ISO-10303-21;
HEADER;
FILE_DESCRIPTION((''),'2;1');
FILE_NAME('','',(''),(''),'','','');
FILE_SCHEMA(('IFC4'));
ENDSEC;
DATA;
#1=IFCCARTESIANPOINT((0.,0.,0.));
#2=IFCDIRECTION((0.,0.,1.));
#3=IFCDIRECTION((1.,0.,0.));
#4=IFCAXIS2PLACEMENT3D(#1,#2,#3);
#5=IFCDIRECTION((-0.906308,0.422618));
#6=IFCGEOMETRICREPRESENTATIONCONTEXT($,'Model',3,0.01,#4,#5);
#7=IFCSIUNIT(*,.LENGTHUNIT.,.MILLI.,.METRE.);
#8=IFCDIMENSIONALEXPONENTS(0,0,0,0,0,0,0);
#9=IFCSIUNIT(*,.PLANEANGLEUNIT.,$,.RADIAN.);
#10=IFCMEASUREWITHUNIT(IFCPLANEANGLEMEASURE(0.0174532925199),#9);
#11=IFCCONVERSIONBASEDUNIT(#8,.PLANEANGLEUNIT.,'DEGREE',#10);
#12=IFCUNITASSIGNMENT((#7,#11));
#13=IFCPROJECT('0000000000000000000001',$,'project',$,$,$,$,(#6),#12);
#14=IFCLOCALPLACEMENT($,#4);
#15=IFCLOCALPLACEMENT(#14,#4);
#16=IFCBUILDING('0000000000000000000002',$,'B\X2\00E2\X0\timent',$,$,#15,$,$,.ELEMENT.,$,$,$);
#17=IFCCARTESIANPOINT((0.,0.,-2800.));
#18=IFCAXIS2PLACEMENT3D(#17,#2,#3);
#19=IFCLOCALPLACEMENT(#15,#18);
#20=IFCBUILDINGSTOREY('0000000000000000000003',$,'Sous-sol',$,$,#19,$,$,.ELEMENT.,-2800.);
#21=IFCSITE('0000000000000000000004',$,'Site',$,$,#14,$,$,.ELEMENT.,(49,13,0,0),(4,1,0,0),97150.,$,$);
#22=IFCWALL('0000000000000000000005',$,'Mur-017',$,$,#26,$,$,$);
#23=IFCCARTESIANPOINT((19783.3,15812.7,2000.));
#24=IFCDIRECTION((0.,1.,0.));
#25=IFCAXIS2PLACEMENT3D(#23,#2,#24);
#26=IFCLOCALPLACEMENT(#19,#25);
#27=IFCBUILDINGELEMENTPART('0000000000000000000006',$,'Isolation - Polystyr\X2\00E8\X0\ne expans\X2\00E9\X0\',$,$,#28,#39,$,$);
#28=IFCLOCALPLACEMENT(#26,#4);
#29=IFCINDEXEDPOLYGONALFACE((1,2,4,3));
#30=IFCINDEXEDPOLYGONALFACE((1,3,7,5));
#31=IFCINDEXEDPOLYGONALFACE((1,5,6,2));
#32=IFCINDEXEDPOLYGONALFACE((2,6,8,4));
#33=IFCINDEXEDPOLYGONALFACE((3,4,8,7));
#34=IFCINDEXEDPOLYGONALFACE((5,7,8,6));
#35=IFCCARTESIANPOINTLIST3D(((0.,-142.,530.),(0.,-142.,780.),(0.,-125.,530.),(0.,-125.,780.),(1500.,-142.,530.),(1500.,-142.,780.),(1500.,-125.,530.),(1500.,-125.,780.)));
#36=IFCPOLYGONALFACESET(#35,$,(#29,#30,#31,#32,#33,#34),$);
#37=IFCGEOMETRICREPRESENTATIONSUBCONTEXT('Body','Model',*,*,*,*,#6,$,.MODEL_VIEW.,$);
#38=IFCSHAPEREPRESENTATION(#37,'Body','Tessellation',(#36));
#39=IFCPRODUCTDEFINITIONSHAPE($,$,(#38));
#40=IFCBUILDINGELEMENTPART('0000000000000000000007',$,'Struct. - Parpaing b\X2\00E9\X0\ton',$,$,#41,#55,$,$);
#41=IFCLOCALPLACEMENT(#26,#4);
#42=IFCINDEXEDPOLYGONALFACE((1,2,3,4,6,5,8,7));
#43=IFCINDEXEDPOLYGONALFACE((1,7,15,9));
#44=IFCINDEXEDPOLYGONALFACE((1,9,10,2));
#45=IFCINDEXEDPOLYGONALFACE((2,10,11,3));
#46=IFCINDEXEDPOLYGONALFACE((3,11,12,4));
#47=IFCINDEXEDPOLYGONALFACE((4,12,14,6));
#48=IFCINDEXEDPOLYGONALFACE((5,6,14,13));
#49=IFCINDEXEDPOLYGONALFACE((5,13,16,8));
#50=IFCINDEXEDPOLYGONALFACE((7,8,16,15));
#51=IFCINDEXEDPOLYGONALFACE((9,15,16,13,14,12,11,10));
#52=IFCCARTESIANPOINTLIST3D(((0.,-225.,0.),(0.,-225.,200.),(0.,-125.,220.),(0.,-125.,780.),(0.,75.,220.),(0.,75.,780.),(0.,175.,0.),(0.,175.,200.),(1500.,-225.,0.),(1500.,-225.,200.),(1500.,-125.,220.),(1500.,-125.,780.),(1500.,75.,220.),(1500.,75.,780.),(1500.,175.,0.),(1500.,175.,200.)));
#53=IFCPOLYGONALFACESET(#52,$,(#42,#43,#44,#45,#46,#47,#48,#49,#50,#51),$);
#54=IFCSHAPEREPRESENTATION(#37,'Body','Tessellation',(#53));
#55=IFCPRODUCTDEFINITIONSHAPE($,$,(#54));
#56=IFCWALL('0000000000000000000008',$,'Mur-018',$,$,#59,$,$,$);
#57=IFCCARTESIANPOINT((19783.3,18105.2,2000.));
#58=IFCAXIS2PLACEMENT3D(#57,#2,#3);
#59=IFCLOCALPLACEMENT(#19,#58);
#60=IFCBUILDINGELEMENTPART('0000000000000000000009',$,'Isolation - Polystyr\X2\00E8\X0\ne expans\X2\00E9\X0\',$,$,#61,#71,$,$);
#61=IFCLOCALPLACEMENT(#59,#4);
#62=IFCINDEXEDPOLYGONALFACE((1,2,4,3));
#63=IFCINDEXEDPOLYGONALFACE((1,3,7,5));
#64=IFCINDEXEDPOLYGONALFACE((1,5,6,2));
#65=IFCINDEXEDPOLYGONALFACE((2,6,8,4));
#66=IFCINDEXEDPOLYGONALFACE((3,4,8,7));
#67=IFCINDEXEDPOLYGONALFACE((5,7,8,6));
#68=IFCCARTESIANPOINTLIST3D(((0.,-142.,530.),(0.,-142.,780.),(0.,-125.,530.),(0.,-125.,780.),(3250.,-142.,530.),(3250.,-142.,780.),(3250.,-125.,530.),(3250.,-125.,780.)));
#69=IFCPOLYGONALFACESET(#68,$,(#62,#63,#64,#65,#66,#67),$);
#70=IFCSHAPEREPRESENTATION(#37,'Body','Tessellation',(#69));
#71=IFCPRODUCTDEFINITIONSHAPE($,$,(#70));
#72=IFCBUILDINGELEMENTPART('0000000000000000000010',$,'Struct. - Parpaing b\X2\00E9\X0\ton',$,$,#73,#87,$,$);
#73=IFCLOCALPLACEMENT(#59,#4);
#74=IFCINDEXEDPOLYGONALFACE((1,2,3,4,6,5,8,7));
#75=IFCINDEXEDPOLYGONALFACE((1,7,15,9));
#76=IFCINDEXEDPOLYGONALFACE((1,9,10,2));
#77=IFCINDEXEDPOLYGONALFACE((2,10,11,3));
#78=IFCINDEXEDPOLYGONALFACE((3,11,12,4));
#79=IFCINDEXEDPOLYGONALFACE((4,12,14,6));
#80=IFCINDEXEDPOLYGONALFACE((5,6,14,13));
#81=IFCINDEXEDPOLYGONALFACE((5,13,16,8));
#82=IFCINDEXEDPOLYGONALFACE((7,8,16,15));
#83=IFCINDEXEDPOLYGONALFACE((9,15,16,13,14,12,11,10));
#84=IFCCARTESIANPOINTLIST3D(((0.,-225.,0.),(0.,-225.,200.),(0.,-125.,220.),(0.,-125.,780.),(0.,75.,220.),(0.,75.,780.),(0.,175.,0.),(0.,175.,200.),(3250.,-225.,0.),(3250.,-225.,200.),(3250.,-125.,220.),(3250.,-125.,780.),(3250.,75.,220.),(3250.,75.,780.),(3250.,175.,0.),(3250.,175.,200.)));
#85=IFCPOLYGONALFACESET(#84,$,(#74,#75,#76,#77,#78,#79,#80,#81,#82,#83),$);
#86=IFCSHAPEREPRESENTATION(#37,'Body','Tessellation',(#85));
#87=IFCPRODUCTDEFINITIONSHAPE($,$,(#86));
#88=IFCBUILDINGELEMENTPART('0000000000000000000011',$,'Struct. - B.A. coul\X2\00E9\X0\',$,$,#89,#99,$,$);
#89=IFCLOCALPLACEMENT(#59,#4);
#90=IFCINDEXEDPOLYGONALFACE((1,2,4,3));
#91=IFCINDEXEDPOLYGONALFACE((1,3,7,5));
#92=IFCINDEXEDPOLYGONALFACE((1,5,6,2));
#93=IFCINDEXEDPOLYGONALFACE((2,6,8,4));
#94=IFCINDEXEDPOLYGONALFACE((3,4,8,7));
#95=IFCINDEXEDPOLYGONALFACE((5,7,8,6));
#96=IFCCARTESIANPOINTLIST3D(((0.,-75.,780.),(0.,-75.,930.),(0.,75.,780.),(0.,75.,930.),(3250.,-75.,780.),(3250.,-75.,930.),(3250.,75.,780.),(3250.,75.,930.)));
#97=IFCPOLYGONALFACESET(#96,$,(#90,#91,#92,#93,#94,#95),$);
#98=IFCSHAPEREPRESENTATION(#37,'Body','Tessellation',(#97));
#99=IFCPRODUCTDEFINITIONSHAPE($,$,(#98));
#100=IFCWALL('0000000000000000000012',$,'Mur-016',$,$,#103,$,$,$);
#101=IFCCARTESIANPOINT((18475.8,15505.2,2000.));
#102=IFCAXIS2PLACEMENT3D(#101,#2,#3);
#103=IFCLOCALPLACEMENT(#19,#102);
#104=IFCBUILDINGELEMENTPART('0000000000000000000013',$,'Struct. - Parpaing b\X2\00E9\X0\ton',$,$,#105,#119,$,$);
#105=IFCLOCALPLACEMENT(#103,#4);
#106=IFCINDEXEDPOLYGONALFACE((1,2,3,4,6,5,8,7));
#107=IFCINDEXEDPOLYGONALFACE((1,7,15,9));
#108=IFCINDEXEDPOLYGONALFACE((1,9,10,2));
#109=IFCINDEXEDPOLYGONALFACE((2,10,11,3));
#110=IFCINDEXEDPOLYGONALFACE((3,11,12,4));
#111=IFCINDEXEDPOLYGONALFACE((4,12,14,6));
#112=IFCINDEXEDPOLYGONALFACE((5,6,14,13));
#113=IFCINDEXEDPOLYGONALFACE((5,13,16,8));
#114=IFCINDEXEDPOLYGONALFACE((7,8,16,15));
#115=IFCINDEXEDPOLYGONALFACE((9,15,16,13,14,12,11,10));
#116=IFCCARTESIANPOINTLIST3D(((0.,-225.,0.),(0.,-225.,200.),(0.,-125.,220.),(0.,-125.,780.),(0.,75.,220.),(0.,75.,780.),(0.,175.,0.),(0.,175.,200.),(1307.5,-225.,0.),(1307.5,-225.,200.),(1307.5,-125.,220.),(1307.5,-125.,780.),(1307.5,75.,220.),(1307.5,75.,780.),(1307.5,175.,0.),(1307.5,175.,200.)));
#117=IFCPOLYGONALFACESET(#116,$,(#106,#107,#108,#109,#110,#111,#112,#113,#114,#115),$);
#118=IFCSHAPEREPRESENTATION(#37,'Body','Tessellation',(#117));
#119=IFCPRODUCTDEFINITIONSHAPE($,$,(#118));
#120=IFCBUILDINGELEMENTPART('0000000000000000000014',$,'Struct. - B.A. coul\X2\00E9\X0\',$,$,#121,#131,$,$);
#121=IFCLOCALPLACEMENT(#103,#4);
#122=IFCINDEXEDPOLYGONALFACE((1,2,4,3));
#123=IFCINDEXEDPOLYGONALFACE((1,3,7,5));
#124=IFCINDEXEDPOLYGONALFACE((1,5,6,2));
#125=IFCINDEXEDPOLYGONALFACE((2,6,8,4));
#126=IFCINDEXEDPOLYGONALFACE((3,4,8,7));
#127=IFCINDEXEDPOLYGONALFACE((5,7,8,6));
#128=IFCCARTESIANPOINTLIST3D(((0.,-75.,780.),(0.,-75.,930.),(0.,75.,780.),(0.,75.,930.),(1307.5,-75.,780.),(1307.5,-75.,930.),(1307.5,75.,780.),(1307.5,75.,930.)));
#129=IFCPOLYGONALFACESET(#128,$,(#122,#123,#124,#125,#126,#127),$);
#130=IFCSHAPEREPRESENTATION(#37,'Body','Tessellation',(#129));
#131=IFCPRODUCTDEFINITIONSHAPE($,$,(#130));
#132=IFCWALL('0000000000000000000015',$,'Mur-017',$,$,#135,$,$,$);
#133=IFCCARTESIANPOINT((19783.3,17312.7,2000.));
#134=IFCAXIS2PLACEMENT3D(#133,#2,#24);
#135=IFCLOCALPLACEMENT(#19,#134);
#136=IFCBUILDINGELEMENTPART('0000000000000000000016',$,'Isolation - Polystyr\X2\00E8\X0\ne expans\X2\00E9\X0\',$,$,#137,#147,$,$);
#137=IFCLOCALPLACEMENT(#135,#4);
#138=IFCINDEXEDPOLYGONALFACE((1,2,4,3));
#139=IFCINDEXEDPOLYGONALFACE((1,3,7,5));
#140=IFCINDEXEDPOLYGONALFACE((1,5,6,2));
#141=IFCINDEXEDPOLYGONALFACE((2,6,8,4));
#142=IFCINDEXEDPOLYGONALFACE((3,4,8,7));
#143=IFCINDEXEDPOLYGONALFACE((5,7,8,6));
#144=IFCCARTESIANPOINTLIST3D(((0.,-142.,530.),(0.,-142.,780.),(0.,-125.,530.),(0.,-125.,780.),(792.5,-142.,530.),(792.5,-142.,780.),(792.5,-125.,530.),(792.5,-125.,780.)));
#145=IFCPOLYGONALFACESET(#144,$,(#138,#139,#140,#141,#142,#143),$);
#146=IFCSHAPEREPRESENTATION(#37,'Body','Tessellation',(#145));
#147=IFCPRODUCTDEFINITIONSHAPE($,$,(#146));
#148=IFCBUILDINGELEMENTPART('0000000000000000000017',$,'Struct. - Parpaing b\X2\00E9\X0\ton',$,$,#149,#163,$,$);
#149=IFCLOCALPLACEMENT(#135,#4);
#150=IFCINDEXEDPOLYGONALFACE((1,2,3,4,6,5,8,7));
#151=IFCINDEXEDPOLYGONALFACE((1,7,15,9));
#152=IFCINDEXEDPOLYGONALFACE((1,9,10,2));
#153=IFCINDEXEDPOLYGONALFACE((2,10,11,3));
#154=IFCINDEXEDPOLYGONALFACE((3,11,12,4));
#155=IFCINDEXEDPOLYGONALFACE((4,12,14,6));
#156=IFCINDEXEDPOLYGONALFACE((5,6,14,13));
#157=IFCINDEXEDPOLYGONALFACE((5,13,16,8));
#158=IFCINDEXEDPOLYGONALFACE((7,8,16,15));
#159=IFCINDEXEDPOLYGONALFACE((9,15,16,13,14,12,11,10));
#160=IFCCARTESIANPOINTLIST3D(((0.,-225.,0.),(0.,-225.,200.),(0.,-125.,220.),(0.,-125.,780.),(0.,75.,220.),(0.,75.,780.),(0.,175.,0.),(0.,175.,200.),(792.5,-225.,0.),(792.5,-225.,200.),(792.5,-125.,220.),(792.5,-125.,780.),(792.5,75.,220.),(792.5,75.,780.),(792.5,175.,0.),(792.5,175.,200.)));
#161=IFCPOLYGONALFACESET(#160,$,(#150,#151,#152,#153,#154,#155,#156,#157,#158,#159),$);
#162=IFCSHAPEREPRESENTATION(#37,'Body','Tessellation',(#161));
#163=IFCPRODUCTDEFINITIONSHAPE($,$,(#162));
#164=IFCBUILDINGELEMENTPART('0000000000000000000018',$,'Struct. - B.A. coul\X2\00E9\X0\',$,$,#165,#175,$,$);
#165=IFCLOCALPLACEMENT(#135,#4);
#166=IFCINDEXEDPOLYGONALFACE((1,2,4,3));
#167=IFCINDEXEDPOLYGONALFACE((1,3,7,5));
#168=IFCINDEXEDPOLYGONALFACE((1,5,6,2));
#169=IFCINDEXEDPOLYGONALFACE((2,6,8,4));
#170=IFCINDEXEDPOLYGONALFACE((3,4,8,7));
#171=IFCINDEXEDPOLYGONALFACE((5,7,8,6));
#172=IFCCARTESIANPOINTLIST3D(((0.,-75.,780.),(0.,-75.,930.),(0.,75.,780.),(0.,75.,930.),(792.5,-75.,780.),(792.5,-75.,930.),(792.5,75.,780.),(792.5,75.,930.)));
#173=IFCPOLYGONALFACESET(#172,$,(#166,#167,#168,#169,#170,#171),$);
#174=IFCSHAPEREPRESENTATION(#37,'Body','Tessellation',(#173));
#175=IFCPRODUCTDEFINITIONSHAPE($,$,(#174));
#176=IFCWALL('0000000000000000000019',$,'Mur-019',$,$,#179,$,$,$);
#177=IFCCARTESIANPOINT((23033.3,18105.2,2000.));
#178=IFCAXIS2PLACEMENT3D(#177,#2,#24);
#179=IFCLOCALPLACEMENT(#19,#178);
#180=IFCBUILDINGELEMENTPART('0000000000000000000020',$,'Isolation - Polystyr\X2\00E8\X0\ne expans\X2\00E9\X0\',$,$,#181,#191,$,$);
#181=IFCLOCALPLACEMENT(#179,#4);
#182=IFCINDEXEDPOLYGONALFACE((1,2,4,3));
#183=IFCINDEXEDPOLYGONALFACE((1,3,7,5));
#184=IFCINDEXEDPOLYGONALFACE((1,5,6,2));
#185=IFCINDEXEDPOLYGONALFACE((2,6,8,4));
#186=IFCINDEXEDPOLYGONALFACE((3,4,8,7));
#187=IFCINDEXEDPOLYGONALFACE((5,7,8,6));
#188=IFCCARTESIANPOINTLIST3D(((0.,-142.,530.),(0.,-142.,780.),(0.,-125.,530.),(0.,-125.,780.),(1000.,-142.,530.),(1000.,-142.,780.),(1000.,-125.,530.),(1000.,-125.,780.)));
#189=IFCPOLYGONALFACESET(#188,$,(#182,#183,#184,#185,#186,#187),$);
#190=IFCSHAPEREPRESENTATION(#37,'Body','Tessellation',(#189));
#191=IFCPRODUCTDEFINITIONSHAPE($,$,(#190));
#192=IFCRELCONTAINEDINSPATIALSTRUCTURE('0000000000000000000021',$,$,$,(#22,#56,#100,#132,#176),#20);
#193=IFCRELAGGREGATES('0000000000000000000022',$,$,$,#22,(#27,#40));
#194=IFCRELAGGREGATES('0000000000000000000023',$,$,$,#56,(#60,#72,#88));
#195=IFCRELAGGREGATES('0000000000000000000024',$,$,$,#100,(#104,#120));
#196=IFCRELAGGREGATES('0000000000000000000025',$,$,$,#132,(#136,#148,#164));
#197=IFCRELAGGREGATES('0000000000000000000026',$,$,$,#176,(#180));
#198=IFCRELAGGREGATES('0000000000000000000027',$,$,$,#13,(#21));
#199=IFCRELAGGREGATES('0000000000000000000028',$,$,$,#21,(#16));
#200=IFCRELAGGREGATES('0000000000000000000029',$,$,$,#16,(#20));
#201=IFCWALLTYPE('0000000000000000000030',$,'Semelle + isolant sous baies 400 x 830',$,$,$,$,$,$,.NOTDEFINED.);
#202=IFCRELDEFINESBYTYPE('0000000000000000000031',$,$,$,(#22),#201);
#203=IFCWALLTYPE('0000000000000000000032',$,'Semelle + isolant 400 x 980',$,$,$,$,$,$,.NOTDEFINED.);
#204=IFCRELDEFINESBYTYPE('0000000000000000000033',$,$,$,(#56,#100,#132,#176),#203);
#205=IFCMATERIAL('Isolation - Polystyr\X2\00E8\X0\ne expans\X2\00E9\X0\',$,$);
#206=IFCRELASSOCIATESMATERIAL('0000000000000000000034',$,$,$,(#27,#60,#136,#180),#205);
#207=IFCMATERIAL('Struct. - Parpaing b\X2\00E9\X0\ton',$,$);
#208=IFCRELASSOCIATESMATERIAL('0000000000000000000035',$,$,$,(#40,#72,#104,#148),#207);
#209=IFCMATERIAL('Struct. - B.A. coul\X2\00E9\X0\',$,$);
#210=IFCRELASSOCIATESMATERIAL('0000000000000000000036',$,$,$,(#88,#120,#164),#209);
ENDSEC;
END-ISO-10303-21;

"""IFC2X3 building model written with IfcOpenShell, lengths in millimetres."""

from ifc_helpers import new_model, entity, si_unit, converted_unit, direction, frame, origin_with_axes, place, context, subcontext, project, spatial, polyline, outline, extrude, material, type_object, element, aggregate, save


model = new_model("IFC2X3")

# Units and contexts
model_context = context("Model", 3, precision=0.01, world=origin_with_axes(), true_north=direction((-0.906308, 0.422618)))
body_context = subcontext(model_context, "Body", "Model", "MODEL_VIEW")
ifc_project = project(units=[si_unit("LENGTHUNIT", "METRE", prefix="MILLI"), converted_unit("PLANEANGLEUNIT", "DEGREE", entity("IfcPlaneAngleMeasure", 0.0174532925199), si_unit("PLANEANGLEUNIT", "RADIAN"), dimensions=[0, 0, 0, 0, 0, 0, 0])], contexts=[model_context])

# Site, building, storey
site_placement = place(None, origin_with_axes())
site = spatial("IfcSite", under=ifc_project, at=site_placement, Name="Site", CompositionType="ELEMENT", RefLatitude=(49, 13, 0, 0), RefLongitude=(4, 1, 0, 0), RefElevation=97150.0)
building_placement = place(site_placement, origin_with_axes())
building = spatial("IfcBuilding", under=site, at=building_placement, Name="Bâtiment", CompositionType="ELEMENT")
storey_placement = place(building_placement, frame((0.0, 0.0, -2800.0), z_axis=(0.0, 0.0, 1.0), x_axis=(1.0, 0.0, 0.0)))
storey = spatial("IfcBuildingStorey", under=building, at=storey_placement, Name="Sous-sol", CompositionType="ELEMENT", Elevation=-2800.0)

# Walls, building element parts
wall_type_1 = type_object("IfcWallType", Name="Semelle + isolant sous baies 400 x 830", PredefinedType="NOTDEFINED")
wall_1_placement = place(storey_placement, frame((19783.3, 15812.7, 2000.0), z_axis=(0.0, 0.0, 1.0), x_axis=(0.0, 1.0, 0.0)))
wall_1 = element("IfcWall", 1, at=wall_1_placement, inside=storey, type_object=wall_type_1, Name="Mur-017")
ifc_material_1 = material(Name="Isolation - Polystyrène expansé")
building_element_part_1_placement = place(wall_1_placement, origin_with_axes())
building_element_part_1 = element("IfcBuildingElementPart", 2, at=building_element_part_1_placement, material=ifc_material_1, Name="Isolation - Polystyrène expansé", context=body_context, shape_type="SweptSolid", body=[
    extrude(outline(polyline([(125.0, 780.0), (125.0, 530.0), (142.0, 530.0), (142.0, 780.0), (125.0, 780.0)])), frame((0.0, 0.0, 0.0), z_axis=(-1.0, 0.0, 0.0), x_axis=(0.0, -1.0, 0.0)), (0.0, 0.0, -1.0), 1500.0),
])
ifc_material_2 = material(Name="Struct. - Parpaing béton")
building_element_part_2_placement = place(wall_1_placement, origin_with_axes())
building_element_part_2 = element("IfcBuildingElementPart", 3, at=building_element_part_2_placement, material=ifc_material_2, Name="Struct. - Parpaing béton", context=body_context, shape_type="SweptSolid", body=[
    extrude(outline(polyline([(-175.0, 200.0), (-175.0, 0.0), (225.0, 0.0), (225.0, 200.0), (125.0, 220.0), (125.0, 780.0), (-75.0, 780.0), (-75.0, 220.0), (-175.0, 200.0)])), frame((0.0, 0.0, 0.0), z_axis=(-1.0, 0.0, 0.0), x_axis=(0.0, -1.0, 0.0)), (0.0, 0.0, -1.0), 1500.0),
])
aggregate(wall_1, [building_element_part_1, building_element_part_2])
wall_type_2 = type_object("IfcWallType", Name="Semelle + isolant 400 x 980", PredefinedType="NOTDEFINED")
wall_2_placement = place(storey_placement, frame((19783.3, 18105.2, 2000.0), z_axis=(0.0, 0.0, 1.0), x_axis=(1.0, 0.0, 0.0)))
wall_2 = element("IfcWall", 4, at=wall_2_placement, inside=storey, type_object=wall_type_2, Name="Mur-018")
building_element_part_3_placement = place(wall_2_placement, origin_with_axes())
building_element_part_3 = element("IfcBuildingElementPart", 5, at=building_element_part_3_placement, material=ifc_material_1, Name="Isolation - Polystyrène expansé", context=body_context, shape_type="SweptSolid", body=[
    extrude(outline(polyline([(125.0, 780.0), (125.0, 530.0), (142.0, 530.0), (142.0, 780.0), (125.0, 780.0)])), frame((0.0, 0.0, 0.0), z_axis=(-1.0, 0.0, 0.0), x_axis=(0.0, -1.0, 0.0)), (0.0, 0.0, -1.0), 3250.0),
])
building_element_part_4_placement = place(wall_2_placement, origin_with_axes())
building_element_part_4 = element("IfcBuildingElementPart", 6, at=building_element_part_4_placement, material=ifc_material_2, Name="Struct. - Parpaing béton", context=body_context, shape_type="SweptSolid", body=[
    extrude(outline(polyline([(-75.0, 220.0), (-175.0, 200.0), (-175.0, 0.0), (225.0, 0.0), (225.0, 200.0), (125.0, 220.0), (125.0, 780.0), (-75.0, 780.0), (-75.0, 220.0)])), frame((0.0, 0.0, 0.0), z_axis=(-1.0, 0.0, 0.0), x_axis=(0.0, -1.0, 0.0)), (0.0, 0.0, -1.0), 3250.0),
])
ifc_material_3 = material(Name="Struct. - B.A. coulé")
building_element_part_5_placement = place(wall_2_placement, origin_with_axes())
building_element_part_5 = element("IfcBuildingElementPart", 7, at=building_element_part_5_placement, material=ifc_material_3, Name="Struct. - B.A. coulé", context=body_context, shape_type="SweptSolid", body=[
    extrude(outline(polyline([(75.0, 780.0), (75.0, 930.0), (-75.0, 930.0), (-75.0, 780.0), (75.0, 780.0)])), frame((0.0, 0.0, 0.0), z_axis=(-1.0, 0.0, 0.0), x_axis=(0.0, -1.0, 0.0)), (0.0, 0.0, -1.0), 3250.0),
])
aggregate(wall_2, [building_element_part_3, building_element_part_4, building_element_part_5])
wall_3_placement = place(storey_placement, frame((18475.8, 15505.2, 2000.0), z_axis=(0.0, 0.0, 1.0), x_axis=(1.0, 0.0, 0.0)))
wall_3 = element("IfcWall", 8, at=wall_3_placement, inside=storey, type_object=wall_type_2, Name="Mur-016")
building_element_part_6_placement = place(wall_3_placement, origin_with_axes())
building_element_part_6 = element("IfcBuildingElementPart", 9, at=building_element_part_6_placement, material=ifc_material_2, Name="Struct. - Parpaing béton", context=body_context, shape_type="SweptSolid", body=[
    extrude(outline(polyline([(-75.0, 220.0), (-175.0, 200.0), (-175.0, 0.0), (225.0, 0.0), (225.0, 200.0), (125.0, 220.0), (125.0, 780.0), (-75.0, 780.0), (-75.0, 220.0)])), frame((0.0, 0.0, 0.0), z_axis=(-1.0, 0.0, 0.0), x_axis=(0.0, -1.0, 0.0)), (0.0, 0.0, -1.0), 1307.5),
])
building_element_part_7_placement = place(wall_3_placement, origin_with_axes())
building_element_part_7 = element("IfcBuildingElementPart", 10, at=building_element_part_7_placement, material=ifc_material_3, Name="Struct. - B.A. coulé", context=body_context, shape_type="SweptSolid", body=[
    extrude(outline(polyline([(75.0, 780.0), (75.0, 930.0), (-75.0, 930.0), (-75.0, 780.0), (75.0, 780.0)])), frame((0.0, 0.0, 0.0), z_axis=(-1.0, 0.0, 0.0), x_axis=(0.0, -1.0, 0.0)), (0.0, 0.0, -1.0), 1307.5),
])
aggregate(wall_3, [building_element_part_6, building_element_part_7])
wall_4_placement = place(storey_placement, frame((19783.3, 17312.7, 2000.0), z_axis=(0.0, 0.0, 1.0), x_axis=(0.0, 1.0, 0.0)))
wall_4 = element("IfcWall", 11, at=wall_4_placement, inside=storey, type_object=wall_type_2, Name="Mur-017")
building_element_part_8_placement = place(wall_4_placement, origin_with_axes())
building_element_part_8 = element("IfcBuildingElementPart", 12, at=building_element_part_8_placement, material=ifc_material_1, Name="Isolation - Polystyrène expansé", context=body_context, shape_type="SweptSolid", body=[
    extrude(outline(polyline([(125.0, 780.0), (125.0, 530.0), (142.0, 530.0), (142.0, 780.0), (125.0, 780.0)])), frame((0.0, 0.0, 0.0), z_axis=(-1.0, 0.0, 0.0), x_axis=(0.0, -1.0, 0.0)), (0.0, 0.0, -1.0), 792.5),
])
building_element_part_9_placement = place(wall_4_placement, origin_with_axes())
building_element_part_9 = element("IfcBuildingElementPart", 13, at=building_element_part_9_placement, material=ifc_material_2, Name="Struct. - Parpaing béton", context=body_context, shape_type="SweptSolid", body=[
    extrude(outline(polyline([(-75.0, 220.0), (-175.0, 200.0), (-175.0, 0.0), (225.0, 0.0), (225.0, 200.0), (125.0, 220.0), (125.0, 780.0), (-75.0, 780.0), (-75.0, 220.0)])), frame((0.0, 0.0, 0.0), z_axis=(-1.0, 0.0, 0.0), x_axis=(0.0, -1.0, 0.0)), (0.0, 0.0, -1.0), 792.5),
])
building_element_part_10_placement = place(wall_4_placement, origin_with_axes())
building_element_part_10 = element("IfcBuildingElementPart", 14, at=building_element_part_10_placement, material=ifc_material_3, Name="Struct. - B.A. coulé", context=body_context, shape_type="SweptSolid", body=[
    extrude(outline(polyline([(75.0, 780.0), (75.0, 930.0), (-75.0, 930.0), (-75.0, 780.0), (75.0, 780.0)])), frame((0.0, 0.0, 0.0), z_axis=(-1.0, 0.0, 0.0), x_axis=(0.0, -1.0, 0.0)), (0.0, 0.0, -1.0), 792.5),
])
aggregate(wall_4, [building_element_part_8, building_element_part_9, building_element_part_10])
wall_5_placement = place(storey_placement, frame((23033.3, 18105.2, 2000.0), z_axis=(0.0, 0.0, 1.0), x_axis=(0.0, 1.0, 0.0)))
wall_5 = element("IfcWall", 15, at=wall_5_placement, inside=storey, type_object=wall_type_2, Name="Mur-019")
building_element_part_11_placement = place(wall_5_placement, origin_with_axes())
building_element_part_11 = element("IfcBuildingElementPart", 16, at=building_element_part_11_placement, material=ifc_material_1, Name="Isolation - Polystyrène expansé", context=body_context, shape_type="SweptSolid", body=[
    extrude(outline(polyline([(125.0, 780.0), (125.0, 530.0), (142.0, 530.0), (142.0, 780.0), (125.0, 780.0)])), frame((0.0, 0.0, 0.0), z_axis=(-1.0, 0.0, 0.0), x_axis=(0.0, -1.0, 0.0)), (0.0, 0.0, -1.0), 1000.0),
])
aggregate(wall_5, [building_element_part_11])

save(model, "model.ifc")
